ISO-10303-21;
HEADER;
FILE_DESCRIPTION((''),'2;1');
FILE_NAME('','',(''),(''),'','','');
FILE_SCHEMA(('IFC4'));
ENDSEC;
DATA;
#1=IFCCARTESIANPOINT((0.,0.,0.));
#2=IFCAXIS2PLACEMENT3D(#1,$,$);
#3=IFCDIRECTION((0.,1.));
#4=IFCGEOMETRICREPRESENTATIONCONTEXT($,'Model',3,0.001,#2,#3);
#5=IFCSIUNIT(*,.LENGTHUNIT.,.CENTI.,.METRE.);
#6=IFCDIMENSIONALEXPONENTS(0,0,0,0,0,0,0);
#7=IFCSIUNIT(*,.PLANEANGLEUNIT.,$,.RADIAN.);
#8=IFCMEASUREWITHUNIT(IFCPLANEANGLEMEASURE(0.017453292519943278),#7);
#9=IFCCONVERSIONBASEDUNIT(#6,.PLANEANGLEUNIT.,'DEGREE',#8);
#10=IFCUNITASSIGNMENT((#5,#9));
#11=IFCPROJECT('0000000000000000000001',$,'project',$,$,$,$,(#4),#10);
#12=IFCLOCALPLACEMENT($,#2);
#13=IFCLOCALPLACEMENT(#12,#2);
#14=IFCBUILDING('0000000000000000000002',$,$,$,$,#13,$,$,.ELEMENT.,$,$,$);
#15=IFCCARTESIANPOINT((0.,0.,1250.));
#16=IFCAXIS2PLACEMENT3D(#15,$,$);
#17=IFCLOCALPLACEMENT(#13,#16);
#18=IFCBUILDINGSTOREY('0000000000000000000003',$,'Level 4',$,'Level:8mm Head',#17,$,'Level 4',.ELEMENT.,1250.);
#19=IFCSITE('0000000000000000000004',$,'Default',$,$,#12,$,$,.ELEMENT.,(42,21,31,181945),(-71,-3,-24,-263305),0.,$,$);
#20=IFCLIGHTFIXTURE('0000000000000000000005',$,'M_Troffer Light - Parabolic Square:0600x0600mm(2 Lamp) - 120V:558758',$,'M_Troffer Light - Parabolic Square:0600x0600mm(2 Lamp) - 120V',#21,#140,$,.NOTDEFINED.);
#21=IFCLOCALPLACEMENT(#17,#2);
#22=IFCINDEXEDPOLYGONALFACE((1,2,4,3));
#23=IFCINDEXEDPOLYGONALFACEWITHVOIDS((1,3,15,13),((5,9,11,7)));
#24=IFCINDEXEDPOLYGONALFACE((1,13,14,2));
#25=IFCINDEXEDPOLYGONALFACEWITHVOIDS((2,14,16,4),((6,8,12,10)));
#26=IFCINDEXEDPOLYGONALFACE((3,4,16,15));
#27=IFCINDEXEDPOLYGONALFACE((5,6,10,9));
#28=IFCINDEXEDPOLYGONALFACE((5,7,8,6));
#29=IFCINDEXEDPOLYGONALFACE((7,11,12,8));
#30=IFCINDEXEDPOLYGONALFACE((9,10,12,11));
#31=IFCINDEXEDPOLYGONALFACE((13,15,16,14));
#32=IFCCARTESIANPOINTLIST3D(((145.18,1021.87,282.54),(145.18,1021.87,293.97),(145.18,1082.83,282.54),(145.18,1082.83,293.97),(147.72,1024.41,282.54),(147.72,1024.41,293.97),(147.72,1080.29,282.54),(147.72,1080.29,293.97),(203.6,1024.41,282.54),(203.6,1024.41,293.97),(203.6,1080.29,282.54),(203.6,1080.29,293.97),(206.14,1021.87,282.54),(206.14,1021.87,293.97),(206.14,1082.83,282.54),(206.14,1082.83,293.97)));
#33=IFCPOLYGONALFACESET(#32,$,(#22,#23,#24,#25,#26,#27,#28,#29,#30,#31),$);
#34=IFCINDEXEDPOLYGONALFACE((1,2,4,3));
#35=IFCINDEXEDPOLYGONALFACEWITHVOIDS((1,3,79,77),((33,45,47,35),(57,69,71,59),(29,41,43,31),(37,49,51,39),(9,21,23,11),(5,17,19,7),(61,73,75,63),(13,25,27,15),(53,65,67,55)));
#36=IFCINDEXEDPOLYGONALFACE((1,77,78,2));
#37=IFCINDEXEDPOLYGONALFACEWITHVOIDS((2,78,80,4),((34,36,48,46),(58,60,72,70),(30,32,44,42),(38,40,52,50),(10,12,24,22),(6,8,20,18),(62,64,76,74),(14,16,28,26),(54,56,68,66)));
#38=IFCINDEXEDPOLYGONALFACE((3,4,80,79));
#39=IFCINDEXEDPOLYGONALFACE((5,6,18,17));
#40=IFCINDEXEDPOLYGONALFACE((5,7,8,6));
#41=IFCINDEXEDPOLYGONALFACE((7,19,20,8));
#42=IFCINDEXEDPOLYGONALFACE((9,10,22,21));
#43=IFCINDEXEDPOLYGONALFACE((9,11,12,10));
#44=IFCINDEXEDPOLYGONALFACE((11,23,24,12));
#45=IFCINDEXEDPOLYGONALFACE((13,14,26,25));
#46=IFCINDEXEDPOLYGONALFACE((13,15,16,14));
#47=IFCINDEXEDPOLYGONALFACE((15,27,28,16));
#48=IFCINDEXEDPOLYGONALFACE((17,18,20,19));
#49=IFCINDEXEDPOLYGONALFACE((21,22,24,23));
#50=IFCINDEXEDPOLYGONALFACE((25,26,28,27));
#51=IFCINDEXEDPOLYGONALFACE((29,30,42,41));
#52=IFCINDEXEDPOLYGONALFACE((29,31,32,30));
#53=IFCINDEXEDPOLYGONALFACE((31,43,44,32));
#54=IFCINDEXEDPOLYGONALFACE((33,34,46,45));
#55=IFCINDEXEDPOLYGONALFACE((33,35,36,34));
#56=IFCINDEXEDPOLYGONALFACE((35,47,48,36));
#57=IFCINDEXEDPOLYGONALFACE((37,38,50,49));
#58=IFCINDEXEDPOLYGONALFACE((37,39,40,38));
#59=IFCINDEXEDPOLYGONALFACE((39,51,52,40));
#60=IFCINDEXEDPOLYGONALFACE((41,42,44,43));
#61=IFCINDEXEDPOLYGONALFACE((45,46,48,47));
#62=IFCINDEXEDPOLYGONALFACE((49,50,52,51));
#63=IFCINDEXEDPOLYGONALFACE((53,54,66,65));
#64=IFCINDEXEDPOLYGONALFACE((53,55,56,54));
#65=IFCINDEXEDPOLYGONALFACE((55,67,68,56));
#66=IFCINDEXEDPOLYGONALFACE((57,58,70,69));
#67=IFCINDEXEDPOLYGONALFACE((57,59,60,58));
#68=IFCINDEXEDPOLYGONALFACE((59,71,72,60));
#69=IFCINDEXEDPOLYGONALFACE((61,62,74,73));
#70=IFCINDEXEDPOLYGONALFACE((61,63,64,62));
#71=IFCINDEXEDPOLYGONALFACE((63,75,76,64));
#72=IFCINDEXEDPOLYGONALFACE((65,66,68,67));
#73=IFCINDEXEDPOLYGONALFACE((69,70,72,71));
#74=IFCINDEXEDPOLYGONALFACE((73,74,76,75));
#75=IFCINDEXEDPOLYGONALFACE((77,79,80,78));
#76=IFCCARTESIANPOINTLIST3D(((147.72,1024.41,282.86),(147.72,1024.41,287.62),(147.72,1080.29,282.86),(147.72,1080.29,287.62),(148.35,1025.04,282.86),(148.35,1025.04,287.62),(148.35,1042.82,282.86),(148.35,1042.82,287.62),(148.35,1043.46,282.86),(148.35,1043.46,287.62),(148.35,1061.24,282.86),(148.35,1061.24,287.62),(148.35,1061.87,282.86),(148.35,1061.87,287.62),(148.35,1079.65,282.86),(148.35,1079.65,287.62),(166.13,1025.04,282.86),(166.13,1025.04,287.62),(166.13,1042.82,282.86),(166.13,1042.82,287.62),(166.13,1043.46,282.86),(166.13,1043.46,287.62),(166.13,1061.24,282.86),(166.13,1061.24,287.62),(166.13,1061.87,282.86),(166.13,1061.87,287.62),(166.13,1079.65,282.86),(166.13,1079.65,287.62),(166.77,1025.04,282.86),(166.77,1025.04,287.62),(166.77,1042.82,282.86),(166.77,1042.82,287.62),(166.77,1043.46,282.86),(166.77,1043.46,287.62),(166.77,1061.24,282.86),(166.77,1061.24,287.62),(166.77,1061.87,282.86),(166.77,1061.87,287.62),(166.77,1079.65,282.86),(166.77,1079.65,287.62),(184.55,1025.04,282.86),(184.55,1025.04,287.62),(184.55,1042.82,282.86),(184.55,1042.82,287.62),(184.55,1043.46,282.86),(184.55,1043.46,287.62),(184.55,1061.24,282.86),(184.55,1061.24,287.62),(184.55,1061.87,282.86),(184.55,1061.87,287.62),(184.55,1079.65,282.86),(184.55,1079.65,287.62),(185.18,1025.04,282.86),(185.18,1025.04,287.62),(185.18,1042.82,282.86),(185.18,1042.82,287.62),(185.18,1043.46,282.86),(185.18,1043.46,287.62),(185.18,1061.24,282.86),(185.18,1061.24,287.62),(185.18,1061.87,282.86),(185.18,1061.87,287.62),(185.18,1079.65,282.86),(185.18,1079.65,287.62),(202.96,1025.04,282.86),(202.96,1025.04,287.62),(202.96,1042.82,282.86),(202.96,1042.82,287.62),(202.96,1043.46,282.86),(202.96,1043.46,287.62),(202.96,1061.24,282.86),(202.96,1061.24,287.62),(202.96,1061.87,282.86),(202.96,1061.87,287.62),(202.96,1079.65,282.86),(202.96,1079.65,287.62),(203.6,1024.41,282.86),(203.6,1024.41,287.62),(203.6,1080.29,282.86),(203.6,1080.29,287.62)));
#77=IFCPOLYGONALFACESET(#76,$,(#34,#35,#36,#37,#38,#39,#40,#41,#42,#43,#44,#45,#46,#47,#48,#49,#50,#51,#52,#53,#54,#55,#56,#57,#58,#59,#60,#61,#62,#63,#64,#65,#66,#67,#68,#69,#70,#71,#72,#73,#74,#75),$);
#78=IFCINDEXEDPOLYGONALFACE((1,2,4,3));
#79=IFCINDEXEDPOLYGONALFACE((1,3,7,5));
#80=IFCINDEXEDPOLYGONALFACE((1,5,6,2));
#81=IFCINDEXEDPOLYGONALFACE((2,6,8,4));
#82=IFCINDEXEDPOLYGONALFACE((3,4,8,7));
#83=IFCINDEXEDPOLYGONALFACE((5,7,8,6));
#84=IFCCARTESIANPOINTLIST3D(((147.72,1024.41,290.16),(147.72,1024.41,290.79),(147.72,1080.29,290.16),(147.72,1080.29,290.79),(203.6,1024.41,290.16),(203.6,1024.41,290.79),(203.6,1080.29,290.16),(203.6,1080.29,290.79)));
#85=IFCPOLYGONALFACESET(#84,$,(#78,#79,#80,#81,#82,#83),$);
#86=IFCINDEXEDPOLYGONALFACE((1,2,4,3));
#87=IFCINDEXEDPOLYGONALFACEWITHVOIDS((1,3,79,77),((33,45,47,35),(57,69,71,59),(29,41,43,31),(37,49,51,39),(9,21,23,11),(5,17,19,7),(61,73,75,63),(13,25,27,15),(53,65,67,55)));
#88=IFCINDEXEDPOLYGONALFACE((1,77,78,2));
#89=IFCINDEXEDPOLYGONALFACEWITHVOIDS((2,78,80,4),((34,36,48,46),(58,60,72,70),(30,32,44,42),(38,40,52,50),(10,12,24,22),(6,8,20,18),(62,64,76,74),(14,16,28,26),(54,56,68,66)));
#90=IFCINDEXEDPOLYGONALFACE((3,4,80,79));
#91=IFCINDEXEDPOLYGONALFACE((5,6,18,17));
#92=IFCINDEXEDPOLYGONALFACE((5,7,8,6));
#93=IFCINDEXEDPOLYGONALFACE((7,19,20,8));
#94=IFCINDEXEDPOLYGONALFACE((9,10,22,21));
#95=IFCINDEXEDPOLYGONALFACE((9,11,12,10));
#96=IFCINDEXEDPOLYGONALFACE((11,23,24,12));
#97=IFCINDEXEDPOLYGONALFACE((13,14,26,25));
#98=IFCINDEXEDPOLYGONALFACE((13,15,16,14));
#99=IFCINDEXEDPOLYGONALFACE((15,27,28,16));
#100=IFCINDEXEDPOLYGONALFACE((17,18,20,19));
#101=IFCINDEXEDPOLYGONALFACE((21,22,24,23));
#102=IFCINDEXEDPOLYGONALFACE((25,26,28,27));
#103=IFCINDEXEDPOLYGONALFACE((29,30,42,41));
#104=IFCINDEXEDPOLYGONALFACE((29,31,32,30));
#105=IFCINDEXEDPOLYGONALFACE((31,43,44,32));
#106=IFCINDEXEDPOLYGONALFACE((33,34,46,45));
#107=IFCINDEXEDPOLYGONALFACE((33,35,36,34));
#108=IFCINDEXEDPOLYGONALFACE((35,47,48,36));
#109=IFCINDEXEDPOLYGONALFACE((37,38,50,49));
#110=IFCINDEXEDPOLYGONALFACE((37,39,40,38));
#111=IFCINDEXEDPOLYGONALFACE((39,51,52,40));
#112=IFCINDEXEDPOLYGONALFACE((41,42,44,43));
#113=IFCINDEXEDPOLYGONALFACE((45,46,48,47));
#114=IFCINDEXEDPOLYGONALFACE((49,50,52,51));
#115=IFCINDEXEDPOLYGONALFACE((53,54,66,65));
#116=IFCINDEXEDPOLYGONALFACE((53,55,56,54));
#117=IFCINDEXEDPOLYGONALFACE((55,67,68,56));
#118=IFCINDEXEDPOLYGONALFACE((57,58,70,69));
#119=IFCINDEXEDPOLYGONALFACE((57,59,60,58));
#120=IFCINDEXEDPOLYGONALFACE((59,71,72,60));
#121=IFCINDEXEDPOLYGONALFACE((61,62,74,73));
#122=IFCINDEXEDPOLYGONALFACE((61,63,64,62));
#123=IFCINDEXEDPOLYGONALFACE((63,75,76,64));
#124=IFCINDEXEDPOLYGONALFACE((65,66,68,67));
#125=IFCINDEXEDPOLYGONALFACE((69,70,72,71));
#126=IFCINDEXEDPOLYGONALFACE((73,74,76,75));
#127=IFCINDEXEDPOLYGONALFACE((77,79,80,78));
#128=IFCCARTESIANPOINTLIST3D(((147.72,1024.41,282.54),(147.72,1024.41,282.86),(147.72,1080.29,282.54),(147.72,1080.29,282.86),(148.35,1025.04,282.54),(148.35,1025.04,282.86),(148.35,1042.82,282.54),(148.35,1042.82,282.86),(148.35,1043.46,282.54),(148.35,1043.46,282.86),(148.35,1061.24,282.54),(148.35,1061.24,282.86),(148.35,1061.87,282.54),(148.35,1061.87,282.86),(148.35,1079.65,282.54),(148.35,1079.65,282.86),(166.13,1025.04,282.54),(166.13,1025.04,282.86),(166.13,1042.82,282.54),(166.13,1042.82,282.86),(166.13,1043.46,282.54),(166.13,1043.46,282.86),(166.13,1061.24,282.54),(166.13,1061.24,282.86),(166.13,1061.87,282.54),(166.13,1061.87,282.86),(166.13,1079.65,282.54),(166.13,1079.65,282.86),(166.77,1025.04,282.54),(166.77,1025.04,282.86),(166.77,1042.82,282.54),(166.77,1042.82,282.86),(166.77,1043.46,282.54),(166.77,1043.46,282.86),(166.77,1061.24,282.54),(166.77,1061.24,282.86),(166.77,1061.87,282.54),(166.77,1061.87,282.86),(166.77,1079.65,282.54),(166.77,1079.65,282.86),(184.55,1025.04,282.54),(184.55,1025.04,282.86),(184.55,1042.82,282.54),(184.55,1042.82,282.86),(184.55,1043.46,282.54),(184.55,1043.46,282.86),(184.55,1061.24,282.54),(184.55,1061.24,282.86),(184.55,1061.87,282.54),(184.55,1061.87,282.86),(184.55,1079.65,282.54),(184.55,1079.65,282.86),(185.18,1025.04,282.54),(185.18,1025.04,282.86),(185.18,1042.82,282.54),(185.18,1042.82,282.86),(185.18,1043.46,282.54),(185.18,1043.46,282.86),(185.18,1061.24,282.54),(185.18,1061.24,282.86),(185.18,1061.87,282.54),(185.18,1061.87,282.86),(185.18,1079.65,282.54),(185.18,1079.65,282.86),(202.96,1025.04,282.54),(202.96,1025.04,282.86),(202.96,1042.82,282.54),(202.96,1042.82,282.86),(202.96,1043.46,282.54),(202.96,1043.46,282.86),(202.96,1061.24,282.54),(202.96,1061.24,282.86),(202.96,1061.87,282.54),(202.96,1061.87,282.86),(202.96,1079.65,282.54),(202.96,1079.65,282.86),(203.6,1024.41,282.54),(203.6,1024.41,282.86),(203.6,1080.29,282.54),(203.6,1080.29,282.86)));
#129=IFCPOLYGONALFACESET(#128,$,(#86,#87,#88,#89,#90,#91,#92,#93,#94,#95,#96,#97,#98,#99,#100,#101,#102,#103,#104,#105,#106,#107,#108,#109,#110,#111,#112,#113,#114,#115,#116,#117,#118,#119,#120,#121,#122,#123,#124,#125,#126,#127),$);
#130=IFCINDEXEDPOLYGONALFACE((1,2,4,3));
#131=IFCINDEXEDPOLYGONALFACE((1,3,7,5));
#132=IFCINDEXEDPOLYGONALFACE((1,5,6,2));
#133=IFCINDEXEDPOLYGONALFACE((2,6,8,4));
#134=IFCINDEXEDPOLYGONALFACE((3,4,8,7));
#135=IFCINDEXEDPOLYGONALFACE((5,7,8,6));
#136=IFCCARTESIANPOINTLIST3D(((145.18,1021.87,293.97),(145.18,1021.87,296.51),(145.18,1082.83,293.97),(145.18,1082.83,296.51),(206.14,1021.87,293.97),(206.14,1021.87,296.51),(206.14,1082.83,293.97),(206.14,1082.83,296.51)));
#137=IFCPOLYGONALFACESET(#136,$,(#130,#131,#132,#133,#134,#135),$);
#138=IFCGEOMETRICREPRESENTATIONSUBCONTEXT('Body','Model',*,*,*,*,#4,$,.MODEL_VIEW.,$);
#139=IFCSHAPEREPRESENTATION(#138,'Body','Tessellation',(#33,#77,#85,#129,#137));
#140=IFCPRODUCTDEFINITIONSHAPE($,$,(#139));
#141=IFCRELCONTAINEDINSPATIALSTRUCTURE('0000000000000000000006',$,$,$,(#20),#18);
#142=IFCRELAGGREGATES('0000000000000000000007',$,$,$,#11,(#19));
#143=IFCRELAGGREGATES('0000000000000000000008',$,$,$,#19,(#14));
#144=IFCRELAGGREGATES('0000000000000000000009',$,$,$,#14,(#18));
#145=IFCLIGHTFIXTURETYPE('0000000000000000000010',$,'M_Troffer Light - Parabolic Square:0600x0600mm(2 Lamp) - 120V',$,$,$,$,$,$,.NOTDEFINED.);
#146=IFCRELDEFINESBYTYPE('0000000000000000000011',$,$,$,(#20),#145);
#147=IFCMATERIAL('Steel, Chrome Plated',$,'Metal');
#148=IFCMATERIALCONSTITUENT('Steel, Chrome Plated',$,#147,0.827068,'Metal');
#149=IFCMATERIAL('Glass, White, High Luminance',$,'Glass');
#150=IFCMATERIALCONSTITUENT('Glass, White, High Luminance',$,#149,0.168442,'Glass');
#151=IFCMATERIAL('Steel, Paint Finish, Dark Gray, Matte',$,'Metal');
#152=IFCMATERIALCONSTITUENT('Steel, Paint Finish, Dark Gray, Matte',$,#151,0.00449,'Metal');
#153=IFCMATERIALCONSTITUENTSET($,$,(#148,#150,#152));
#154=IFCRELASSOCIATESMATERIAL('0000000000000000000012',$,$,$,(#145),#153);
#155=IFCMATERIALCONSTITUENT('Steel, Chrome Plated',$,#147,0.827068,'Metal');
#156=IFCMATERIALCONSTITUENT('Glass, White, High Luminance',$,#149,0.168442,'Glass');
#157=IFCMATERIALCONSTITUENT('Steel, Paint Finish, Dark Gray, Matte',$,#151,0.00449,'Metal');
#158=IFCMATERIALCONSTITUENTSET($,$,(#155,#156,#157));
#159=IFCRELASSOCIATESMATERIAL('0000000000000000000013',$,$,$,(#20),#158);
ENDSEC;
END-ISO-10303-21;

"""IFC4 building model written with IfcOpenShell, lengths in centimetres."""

from ifc_helpers import new_model, entity, si_unit, converted_unit, direction, frame, origin, place, context, subcontext, project, spatial, indexed_curve, outline, extrude, source, transform, mapped, material, constituent, constituent_set, type_object, type_shapes, element, save


model = new_model("IFC4")

# Units and contexts
model_context = context("Model", 3, precision=0.001, world=origin(), true_north=direction((0.0, 1.0)))
body_context = subcontext(model_context, "Body", "Model", "MODEL_VIEW")
ifc_project = project(units=[si_unit("LENGTHUNIT", "METRE", prefix="CENTI"), converted_unit("PLANEANGLEUNIT", "DEGREE", entity("IfcPlaneAngleMeasure", 0.017453292519943278), si_unit("PLANEANGLEUNIT", "RADIAN"), dimensions=[0, 0, 0, 0, 0, 0, 0])], contexts=[model_context])

# Site, building, storey
site_placement = place(None, origin())
site = spatial("IfcSite", under=ifc_project, at=site_placement, Name="Default", CompositionType="ELEMENT", RefLatitude=(42, 21, 31, 181945), RefLongitude=(-71, -3, -24, -263305), RefElevation=0.0)
building_placement = place(site_placement, origin())
building = spatial("IfcBuilding", under=site, at=building_placement, CompositionType="ELEMENT")
storey_placement = place(building_placement, frame((0.0, 0.0, 1250.0)))
storey = spatial("IfcBuildingStorey", under=building, at=storey_placement, Name="Level 4", ObjectType="Level:8mm Head", LongName="Level 4", CompositionType="ELEMENT", Elevation=1250.0)

# Light fixture
ifc_material_1 = material(Name="Steel, Chrome Plated", Category="Metal")
ifc_material_2 = material(Name="Glass, White, High Luminance", Category="Glass")
ifc_material_3 = material(Name="Steel, Paint Finish, Dark Gray, Matte", Category="Metal")
ifc_constituent_1 = constituent(ifc_material_1, Name="Steel, Chrome Plated", Category="Metal", fraction=0.827068)
ifc_constituent_2 = constituent(ifc_material_2, Name="Glass, White, High Luminance", Category="Glass", fraction=0.168442)
ifc_constituent_3 = constituent(ifc_material_3, Name="Steel, Paint Finish, Dark Gray, Matte", Category="Metal", fraction=0.00449)
ifc_constituent_set_1 = constituent_set(constituents=[ifc_constituent_1, ifc_constituent_2, ifc_constituent_3])
ifc_constituent_4 = constituent(ifc_material_1, Name="Steel, Chrome Plated", Category="Metal", fraction=0.827068)
ifc_constituent_5 = constituent(ifc_material_2, Name="Glass, White, High Luminance", Category="Glass", fraction=0.168442)
ifc_constituent_6 = constituent(ifc_material_3, Name="Steel, Paint Finish, Dark Gray, Matte", Category="Metal", fraction=0.00449)
ifc_constituent_set_2 = constituent_set(constituents=[ifc_constituent_4, ifc_constituent_5, ifc_constituent_6])
light_fixture_type_1 = type_object("IfcLightFixtureType", Name="M_Troffer Light - Parabolic Square:0600x0600mm(2 Lamp) - 120V", PredefinedType="NOTDEFINED", material=ifc_constituent_set_2)
shared_shape_1 = source(origin(), body_context, "Body", "SweptSolid", [
    extrude(outline(indexed_curve([(-30.48, -30.48), (30.48, -30.48), (30.48, 30.48), (-30.48, 30.48), (-30.48, -30.48)], self_intersect=False), holes=[indexed_curve([(-27.94, -27.94), (-27.94, 27.94), (27.94, 27.94), (27.94, -27.94), (-27.94, -27.94)], self_intersect=False)]), frame((-1.87, -5.95, 243.84), z_axis=(0.0, 0.0, 1.0), x_axis=(-1.0, 0.0, 0.0)), (0.0, 0.0, 1.0), 11.43),
    extrude(outline(indexed_curve([(-27.94, -27.94), (27.94, -27.94), (27.94, 27.94), (-27.94, 27.94), (-27.94, -27.94)], self_intersect=False), holes=[indexed_curve([(9.52, -9.52), (27.31, -9.52), (27.31, -27.3), (9.52, -27.3), (9.52, -9.52)], self_intersect=False), indexed_curve([(9.52, 8.89), (27.3, 8.89), (27.3, -8.89), (9.52, -8.89), (9.52, 8.89)], self_intersect=False), indexed_curve([(9.52, 9.53), (9.52, 27.31), (27.3, 27.31), (27.3, 9.53), (9.52, 9.53)], self_intersect=False), indexed_curve([(-8.89, -9.52), (8.89, -9.52), (8.89, -27.3), (-8.89, -27.3), (-8.89, -9.52)], self_intersect=False), indexed_curve([(-8.89, 8.89), (8.89, 8.89), (8.89, -8.89), (-8.89, -8.89), (-8.89, 8.89)], self_intersect=False), indexed_curve([(-8.89, 9.53), (-8.89, 27.31), (8.89, 27.31), (8.89, 9.53), (-8.89, 9.53)], self_intersect=False), indexed_curve([(-27.31, -9.52), (-9.53, -9.52), (-9.53, -27.31), (-27.31, -27.31), (-27.31, -9.52)], self_intersect=False), indexed_curve([(-27.31, 8.89), (-9.52, 8.89), (-9.52, -8.89), (-27.31, -8.89), (-27.31, 8.89)], self_intersect=False), indexed_curve([(-27.31, 9.53), (-27.31, 27.31), (-9.52, 27.31), (-9.52, 9.53), (-27.31, 9.53)], self_intersect=False)]), frame((-1.87, -5.95, 244.16), z_axis=(0.0, 0.0, 1.0), x_axis=(-1.0, 0.0, 0.0)), (0.0, 0.0, 1.0), 4.76),
    extrude(outline(indexed_curve([(-27.94, -27.94), (27.94, -27.94), (27.94, 27.94), (-27.94, 27.94), (-27.94, -27.94)], self_intersect=False)), frame((-1.87, -5.95, 251.46), z_axis=(0.0, 0.0, 1.0), x_axis=(-1.0, 0.0, 0.0)), (0.0, 0.0, 1.0), 0.64),
    extrude(outline(indexed_curve([(-27.94, -27.94), (27.94, -27.94), (27.94, 27.94), (-27.94, 27.94), (-27.94, -27.94)], self_intersect=False), holes=[indexed_curve([(9.52, -9.52), (27.31, -9.52), (27.31, -27.3), (9.52, -27.3), (9.52, -9.52)], self_intersect=False), indexed_curve([(9.52, 8.89), (27.3, 8.89), (27.3, -8.89), (9.52, -8.89), (9.52, 8.89)], self_intersect=False), indexed_curve([(9.52, 9.53), (9.52, 27.31), (27.3, 27.31), (27.3, 9.53), (9.52, 9.53)], self_intersect=False), indexed_curve([(-8.89, -9.52), (8.89, -9.52), (8.89, -27.3), (-8.89, -27.3), (-8.89, -9.52)], self_intersect=False), indexed_curve([(-8.89, 8.89), (8.89, 8.89), (8.89, -8.89), (-8.89, -8.89), (-8.89, 8.89)], self_intersect=False), indexed_curve([(-8.89, 9.53), (-8.89, 27.31), (8.89, 27.31), (8.89, 9.53), (-8.89, 9.53)], self_intersect=False), indexed_curve([(-27.31, -9.52), (-9.53, -9.52), (-9.53, -27.31), (-27.31, -27.31), (-27.31, -9.52)], self_intersect=False), indexed_curve([(-27.31, 8.89), (-9.52, 8.89), (-9.52, -8.89), (-27.31, -8.89), (-27.31, 8.89)], self_intersect=False), indexed_curve([(-27.31, 9.53), (-27.31, 27.31), (-9.52, 27.31), (-9.52, 9.53), (-27.31, 9.53)], self_intersect=False)]), frame((-1.87, -5.95, 243.84), z_axis=(0.0, 0.0, 1.0), x_axis=(-1.0, 0.0, 0.0)), (0.0, 0.0, 1.0), 0.32),
    extrude(outline(indexed_curve([(-30.48, -30.48), (30.48, -30.48), (30.48, 30.48), (-30.48, 30.48), (-30.48, -30.48)], self_intersect=False)), frame((-1.87, -5.95, 255.27), z_axis=(0.0, 0.0, 1.0), x_axis=(-1.0, 0.0, 0.0)), (0.0, 0.0, 1.0), 2.54),
])
type_shapes(light_fixture_type_1, [shared_shape_1])
light_fixture_1_placement = place(storey_placement, frame((177.53, 1058.29, 38.7)))
element("IfcLightFixture", 1, at=light_fixture_1_placement, inside=storey, type_object=light_fixture_type_1, material=ifc_constituent_set_1, Name="M_Troffer Light - Parabolic Square:0600x0600mm(2 Lamp) - 120V:558758", ObjectType="M_Troffer Light - Parabolic Square:0600x0600mm(2 Lamp) - 120V", PredefinedType="NOTDEFINED", context=body_context, shape_type="MappedRepresentation", body=[
    mapped(shared_shape_1, transform((0.0, 0.0, 0.0), scale=1.0)),
])

save(model, "model.ifc")
